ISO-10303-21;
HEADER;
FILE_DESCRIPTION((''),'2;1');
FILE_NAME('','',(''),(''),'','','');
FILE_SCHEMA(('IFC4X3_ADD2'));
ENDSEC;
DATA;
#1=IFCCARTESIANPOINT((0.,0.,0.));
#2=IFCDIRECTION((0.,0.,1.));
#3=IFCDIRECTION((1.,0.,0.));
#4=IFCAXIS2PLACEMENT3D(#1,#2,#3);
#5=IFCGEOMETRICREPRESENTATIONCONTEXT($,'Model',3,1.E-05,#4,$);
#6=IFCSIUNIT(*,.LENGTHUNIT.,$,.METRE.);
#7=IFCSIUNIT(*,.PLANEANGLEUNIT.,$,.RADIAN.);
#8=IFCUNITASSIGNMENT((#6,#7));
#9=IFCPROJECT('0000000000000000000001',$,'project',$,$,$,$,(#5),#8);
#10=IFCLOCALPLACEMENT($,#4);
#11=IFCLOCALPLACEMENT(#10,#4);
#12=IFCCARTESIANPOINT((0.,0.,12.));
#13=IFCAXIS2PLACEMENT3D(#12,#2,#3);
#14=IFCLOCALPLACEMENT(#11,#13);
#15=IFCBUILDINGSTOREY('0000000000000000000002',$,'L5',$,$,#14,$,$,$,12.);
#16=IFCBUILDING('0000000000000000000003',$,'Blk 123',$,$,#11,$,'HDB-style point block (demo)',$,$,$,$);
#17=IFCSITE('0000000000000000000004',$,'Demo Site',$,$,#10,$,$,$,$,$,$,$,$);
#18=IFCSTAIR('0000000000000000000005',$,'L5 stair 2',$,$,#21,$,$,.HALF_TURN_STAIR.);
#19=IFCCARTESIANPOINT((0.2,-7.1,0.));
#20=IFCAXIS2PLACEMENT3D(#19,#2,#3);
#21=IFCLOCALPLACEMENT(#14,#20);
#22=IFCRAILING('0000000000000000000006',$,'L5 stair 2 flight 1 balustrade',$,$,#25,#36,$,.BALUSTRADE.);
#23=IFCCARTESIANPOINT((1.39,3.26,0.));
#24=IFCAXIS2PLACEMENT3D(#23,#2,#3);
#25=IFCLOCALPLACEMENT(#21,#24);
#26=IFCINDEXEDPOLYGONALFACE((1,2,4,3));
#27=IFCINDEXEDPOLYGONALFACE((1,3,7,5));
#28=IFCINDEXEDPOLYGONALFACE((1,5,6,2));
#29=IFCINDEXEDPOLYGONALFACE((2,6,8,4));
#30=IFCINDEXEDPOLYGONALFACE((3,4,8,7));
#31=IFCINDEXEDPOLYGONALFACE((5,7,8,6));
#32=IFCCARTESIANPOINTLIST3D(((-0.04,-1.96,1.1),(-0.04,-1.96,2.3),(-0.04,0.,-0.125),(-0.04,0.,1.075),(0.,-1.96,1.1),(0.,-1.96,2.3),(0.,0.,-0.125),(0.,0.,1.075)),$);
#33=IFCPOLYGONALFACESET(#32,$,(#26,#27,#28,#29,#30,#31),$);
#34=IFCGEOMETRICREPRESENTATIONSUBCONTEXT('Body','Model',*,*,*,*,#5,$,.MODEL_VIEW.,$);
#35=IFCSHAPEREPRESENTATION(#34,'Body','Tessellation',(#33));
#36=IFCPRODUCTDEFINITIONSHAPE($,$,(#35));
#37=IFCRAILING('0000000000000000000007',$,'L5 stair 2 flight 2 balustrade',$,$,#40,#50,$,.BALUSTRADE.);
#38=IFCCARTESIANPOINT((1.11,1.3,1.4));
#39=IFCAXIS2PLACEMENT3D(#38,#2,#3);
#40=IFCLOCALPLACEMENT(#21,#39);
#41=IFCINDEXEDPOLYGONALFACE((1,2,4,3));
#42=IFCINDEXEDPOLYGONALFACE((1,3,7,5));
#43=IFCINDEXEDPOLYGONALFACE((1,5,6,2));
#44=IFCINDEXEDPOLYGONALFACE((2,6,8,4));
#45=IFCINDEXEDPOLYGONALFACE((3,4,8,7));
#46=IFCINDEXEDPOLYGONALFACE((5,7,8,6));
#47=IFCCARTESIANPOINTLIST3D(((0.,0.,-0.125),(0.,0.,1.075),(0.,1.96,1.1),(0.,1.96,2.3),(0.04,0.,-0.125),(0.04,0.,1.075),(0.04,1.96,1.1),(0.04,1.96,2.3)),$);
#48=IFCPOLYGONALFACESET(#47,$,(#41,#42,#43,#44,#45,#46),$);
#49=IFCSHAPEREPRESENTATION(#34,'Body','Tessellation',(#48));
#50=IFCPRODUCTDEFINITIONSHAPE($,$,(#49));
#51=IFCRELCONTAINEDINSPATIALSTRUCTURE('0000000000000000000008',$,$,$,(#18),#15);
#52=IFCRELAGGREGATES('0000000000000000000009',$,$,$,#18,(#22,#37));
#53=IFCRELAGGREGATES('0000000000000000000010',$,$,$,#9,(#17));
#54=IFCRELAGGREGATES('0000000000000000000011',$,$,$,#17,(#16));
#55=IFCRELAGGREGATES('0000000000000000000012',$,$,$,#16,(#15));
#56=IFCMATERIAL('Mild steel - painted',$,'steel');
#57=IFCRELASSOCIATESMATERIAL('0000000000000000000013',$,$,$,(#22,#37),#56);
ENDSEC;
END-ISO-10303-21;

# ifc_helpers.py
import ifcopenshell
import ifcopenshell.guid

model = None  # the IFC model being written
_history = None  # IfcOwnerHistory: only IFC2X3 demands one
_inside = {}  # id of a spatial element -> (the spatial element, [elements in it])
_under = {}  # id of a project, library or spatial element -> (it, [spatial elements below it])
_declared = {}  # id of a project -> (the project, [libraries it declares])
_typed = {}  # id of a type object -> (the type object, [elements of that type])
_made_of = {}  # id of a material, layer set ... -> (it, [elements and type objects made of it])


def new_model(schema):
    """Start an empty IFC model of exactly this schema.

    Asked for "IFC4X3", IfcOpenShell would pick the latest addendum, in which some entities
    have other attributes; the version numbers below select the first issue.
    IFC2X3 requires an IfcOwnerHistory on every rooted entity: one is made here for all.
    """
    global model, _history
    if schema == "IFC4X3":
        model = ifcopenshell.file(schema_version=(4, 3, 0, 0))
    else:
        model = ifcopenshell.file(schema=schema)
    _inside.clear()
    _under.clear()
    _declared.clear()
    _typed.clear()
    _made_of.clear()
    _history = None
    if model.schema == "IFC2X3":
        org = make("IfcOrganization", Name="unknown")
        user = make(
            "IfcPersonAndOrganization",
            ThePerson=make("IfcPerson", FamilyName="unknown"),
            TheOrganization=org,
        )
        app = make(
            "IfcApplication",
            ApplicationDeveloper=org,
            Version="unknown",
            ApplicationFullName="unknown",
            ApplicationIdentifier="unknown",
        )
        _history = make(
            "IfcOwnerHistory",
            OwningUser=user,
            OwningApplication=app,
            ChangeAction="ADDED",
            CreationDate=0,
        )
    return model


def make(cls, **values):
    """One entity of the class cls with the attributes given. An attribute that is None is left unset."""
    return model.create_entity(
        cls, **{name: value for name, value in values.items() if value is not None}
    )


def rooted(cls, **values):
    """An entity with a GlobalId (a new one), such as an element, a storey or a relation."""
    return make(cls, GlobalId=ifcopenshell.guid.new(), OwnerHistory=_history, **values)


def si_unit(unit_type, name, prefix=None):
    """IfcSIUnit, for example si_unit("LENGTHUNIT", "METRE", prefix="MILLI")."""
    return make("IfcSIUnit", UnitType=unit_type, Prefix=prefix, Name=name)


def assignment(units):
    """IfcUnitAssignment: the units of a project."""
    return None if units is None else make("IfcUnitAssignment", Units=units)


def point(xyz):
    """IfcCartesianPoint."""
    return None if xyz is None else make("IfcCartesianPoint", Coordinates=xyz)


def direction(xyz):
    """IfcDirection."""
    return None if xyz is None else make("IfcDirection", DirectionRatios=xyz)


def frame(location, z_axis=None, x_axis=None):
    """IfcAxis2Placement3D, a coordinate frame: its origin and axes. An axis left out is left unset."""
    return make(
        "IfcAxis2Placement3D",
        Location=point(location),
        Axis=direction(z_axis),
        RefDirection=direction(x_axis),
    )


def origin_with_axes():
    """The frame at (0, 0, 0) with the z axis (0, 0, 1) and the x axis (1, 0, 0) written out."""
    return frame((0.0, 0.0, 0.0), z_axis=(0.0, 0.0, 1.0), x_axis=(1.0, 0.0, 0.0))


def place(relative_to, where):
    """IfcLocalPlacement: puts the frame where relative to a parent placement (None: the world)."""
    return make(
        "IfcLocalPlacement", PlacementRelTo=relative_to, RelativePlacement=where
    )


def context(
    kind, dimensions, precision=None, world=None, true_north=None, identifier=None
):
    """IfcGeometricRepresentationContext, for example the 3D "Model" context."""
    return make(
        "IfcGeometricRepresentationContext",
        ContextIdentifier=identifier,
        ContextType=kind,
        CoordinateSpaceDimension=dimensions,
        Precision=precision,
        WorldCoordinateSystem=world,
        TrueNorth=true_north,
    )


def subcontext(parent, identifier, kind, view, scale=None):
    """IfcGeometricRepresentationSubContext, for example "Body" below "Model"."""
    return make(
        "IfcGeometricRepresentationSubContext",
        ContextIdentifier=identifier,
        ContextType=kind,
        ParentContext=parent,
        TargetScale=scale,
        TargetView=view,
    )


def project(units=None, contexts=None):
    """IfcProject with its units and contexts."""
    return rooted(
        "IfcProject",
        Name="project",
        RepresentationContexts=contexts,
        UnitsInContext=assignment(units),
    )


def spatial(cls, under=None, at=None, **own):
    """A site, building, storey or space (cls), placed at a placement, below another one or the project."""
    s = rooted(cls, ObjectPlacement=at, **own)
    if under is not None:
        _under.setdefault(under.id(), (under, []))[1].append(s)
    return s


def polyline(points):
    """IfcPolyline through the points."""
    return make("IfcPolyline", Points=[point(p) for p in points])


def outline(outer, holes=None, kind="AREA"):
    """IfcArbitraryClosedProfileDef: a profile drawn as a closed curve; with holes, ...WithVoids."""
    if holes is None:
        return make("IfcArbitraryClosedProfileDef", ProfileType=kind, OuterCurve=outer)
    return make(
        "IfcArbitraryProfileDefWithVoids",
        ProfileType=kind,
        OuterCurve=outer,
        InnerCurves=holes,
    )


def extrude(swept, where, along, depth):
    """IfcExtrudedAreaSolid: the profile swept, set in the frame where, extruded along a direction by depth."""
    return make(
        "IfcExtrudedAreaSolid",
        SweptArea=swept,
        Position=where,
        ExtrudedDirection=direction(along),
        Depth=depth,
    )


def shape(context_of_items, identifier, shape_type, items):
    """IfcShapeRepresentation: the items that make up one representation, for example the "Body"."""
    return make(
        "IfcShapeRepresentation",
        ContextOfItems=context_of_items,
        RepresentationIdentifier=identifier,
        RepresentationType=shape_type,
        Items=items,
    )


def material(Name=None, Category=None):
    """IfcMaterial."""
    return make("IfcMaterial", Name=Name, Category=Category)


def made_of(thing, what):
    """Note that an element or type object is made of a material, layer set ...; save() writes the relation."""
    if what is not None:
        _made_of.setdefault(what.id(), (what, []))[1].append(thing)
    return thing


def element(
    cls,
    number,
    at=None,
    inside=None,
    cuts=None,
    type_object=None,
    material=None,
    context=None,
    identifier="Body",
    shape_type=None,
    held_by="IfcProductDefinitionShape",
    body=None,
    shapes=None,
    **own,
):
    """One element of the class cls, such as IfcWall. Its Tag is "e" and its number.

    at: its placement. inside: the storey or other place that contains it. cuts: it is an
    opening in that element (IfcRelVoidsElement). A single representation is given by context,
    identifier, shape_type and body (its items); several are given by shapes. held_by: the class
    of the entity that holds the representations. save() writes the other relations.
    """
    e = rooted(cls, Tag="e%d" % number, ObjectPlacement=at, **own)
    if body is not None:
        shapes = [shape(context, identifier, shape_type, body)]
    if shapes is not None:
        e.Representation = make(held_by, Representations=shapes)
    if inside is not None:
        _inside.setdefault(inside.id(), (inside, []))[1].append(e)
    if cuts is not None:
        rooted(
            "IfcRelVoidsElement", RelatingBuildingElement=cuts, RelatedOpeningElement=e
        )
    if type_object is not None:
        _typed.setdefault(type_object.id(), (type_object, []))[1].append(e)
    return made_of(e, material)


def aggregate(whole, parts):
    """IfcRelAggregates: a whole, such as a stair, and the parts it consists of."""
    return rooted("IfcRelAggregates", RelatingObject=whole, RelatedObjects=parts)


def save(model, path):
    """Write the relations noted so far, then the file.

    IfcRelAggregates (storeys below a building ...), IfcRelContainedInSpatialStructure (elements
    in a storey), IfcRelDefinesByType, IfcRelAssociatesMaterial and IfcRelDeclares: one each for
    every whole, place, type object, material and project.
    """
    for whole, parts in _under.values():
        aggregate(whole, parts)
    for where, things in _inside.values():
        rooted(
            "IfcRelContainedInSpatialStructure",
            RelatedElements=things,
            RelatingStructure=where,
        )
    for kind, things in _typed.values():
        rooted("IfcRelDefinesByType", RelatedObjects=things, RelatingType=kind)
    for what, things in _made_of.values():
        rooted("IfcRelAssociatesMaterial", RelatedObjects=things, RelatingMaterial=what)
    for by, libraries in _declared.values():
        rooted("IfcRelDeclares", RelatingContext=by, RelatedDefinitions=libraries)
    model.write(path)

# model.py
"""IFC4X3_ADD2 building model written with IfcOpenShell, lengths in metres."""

from ifc_helpers import new_model, si_unit, frame, origin_with_axes, place, context, subcontext, project, spatial, polyline, outline, extrude, material, element, aggregate, save


model = new_model("IFC4X3_ADD2")

# Units and contexts
model_context = context("Model", 3, precision=1e-05, world=origin_with_axes())
body_context = subcontext(model_context, "Body", "Model", "MODEL_VIEW")
ifc_project = project(units=[si_unit("LENGTHUNIT", "METRE"), si_unit("PLANEANGLEUNIT", "RADIAN")], contexts=[model_context])

# Site, building, storey
site_placement = place(None, origin_with_axes())
site = spatial("IfcSite", under=ifc_project, at=site_placement, Name="Demo Site")
building_placement = place(site_placement, origin_with_axes())
building = spatial("IfcBuilding", under=site, at=building_placement, Name="Blk 123", LongName="HDB-style point block (demo)")
storey_placement = place(building_placement, frame((0.0, 0.0, 12.0), z_axis=(0.0, 0.0, 1.0), x_axis=(1.0, 0.0, 0.0)))
storey = spatial("IfcBuildingStorey", under=building, at=storey_placement, Name="L5", Elevation=12.0)

# Stair
stair_placement = place(storey_placement, frame((0.2, -7.1, 0.0), z_axis=(0.0, 0.0, 1.0), x_axis=(1.0, 0.0, 0.0)))
stair = element("IfcStair", 1, at=stair_placement, inside=storey, Name="L5 stair 2", PredefinedType="HALF_TURN_STAIR")

# Railings
ifc_material_1 = material(Name="Mild steel - painted", Category="steel")
railing_1_placement = place(stair_placement, frame((1.39, 3.26, 0.0), z_axis=(0.0, 0.0, 1.0), x_axis=(1.0, 0.0, 0.0)))
railing_1 = element("IfcRailing", 2, at=railing_1_placement, material=ifc_material_1, Name="L5 stair 2 flight 1 balustrade", PredefinedType="BALUSTRADE", context=body_context, shape_type="SweptSolid", body=[
    extrude(outline(polyline([(0.0, -0.125), (1.96, 1.1), (1.96, 2.3), (0.0, 1.075), (0.0, -0.125)])), frame((0.0, 0.0, 0.0), z_axis=(-1.0, 0.0, 0.0), x_axis=(0.0, -1.0, 0.0)), (0.0, 0.0, 1.0), 0.04),
])
railing_2_placement = place(stair_placement, frame((1.11, 1.3, 1.4), z_axis=(0.0, 0.0, 1.0), x_axis=(1.0, 0.0, 0.0)))
railing_2 = element("IfcRailing", 3, at=railing_2_placement, material=ifc_material_1, Name="L5 stair 2 flight 2 balustrade", PredefinedType="BALUSTRADE", context=body_context, shape_type="SweptSolid", body=[
    extrude(outline(polyline([(0.0, -0.125), (1.96, 1.1), (1.96, 2.3), (0.0, 1.075), (0.0, -0.125)])), frame((0.0, 0.0, 0.0), z_axis=(1.0, 0.0, 0.0), x_axis=(0.0, 1.0, 0.0)), (0.0, 0.0, 1.0), 0.04),
])
aggregate(stair, [railing_1, railing_2])

save(model, "model.ifc")
